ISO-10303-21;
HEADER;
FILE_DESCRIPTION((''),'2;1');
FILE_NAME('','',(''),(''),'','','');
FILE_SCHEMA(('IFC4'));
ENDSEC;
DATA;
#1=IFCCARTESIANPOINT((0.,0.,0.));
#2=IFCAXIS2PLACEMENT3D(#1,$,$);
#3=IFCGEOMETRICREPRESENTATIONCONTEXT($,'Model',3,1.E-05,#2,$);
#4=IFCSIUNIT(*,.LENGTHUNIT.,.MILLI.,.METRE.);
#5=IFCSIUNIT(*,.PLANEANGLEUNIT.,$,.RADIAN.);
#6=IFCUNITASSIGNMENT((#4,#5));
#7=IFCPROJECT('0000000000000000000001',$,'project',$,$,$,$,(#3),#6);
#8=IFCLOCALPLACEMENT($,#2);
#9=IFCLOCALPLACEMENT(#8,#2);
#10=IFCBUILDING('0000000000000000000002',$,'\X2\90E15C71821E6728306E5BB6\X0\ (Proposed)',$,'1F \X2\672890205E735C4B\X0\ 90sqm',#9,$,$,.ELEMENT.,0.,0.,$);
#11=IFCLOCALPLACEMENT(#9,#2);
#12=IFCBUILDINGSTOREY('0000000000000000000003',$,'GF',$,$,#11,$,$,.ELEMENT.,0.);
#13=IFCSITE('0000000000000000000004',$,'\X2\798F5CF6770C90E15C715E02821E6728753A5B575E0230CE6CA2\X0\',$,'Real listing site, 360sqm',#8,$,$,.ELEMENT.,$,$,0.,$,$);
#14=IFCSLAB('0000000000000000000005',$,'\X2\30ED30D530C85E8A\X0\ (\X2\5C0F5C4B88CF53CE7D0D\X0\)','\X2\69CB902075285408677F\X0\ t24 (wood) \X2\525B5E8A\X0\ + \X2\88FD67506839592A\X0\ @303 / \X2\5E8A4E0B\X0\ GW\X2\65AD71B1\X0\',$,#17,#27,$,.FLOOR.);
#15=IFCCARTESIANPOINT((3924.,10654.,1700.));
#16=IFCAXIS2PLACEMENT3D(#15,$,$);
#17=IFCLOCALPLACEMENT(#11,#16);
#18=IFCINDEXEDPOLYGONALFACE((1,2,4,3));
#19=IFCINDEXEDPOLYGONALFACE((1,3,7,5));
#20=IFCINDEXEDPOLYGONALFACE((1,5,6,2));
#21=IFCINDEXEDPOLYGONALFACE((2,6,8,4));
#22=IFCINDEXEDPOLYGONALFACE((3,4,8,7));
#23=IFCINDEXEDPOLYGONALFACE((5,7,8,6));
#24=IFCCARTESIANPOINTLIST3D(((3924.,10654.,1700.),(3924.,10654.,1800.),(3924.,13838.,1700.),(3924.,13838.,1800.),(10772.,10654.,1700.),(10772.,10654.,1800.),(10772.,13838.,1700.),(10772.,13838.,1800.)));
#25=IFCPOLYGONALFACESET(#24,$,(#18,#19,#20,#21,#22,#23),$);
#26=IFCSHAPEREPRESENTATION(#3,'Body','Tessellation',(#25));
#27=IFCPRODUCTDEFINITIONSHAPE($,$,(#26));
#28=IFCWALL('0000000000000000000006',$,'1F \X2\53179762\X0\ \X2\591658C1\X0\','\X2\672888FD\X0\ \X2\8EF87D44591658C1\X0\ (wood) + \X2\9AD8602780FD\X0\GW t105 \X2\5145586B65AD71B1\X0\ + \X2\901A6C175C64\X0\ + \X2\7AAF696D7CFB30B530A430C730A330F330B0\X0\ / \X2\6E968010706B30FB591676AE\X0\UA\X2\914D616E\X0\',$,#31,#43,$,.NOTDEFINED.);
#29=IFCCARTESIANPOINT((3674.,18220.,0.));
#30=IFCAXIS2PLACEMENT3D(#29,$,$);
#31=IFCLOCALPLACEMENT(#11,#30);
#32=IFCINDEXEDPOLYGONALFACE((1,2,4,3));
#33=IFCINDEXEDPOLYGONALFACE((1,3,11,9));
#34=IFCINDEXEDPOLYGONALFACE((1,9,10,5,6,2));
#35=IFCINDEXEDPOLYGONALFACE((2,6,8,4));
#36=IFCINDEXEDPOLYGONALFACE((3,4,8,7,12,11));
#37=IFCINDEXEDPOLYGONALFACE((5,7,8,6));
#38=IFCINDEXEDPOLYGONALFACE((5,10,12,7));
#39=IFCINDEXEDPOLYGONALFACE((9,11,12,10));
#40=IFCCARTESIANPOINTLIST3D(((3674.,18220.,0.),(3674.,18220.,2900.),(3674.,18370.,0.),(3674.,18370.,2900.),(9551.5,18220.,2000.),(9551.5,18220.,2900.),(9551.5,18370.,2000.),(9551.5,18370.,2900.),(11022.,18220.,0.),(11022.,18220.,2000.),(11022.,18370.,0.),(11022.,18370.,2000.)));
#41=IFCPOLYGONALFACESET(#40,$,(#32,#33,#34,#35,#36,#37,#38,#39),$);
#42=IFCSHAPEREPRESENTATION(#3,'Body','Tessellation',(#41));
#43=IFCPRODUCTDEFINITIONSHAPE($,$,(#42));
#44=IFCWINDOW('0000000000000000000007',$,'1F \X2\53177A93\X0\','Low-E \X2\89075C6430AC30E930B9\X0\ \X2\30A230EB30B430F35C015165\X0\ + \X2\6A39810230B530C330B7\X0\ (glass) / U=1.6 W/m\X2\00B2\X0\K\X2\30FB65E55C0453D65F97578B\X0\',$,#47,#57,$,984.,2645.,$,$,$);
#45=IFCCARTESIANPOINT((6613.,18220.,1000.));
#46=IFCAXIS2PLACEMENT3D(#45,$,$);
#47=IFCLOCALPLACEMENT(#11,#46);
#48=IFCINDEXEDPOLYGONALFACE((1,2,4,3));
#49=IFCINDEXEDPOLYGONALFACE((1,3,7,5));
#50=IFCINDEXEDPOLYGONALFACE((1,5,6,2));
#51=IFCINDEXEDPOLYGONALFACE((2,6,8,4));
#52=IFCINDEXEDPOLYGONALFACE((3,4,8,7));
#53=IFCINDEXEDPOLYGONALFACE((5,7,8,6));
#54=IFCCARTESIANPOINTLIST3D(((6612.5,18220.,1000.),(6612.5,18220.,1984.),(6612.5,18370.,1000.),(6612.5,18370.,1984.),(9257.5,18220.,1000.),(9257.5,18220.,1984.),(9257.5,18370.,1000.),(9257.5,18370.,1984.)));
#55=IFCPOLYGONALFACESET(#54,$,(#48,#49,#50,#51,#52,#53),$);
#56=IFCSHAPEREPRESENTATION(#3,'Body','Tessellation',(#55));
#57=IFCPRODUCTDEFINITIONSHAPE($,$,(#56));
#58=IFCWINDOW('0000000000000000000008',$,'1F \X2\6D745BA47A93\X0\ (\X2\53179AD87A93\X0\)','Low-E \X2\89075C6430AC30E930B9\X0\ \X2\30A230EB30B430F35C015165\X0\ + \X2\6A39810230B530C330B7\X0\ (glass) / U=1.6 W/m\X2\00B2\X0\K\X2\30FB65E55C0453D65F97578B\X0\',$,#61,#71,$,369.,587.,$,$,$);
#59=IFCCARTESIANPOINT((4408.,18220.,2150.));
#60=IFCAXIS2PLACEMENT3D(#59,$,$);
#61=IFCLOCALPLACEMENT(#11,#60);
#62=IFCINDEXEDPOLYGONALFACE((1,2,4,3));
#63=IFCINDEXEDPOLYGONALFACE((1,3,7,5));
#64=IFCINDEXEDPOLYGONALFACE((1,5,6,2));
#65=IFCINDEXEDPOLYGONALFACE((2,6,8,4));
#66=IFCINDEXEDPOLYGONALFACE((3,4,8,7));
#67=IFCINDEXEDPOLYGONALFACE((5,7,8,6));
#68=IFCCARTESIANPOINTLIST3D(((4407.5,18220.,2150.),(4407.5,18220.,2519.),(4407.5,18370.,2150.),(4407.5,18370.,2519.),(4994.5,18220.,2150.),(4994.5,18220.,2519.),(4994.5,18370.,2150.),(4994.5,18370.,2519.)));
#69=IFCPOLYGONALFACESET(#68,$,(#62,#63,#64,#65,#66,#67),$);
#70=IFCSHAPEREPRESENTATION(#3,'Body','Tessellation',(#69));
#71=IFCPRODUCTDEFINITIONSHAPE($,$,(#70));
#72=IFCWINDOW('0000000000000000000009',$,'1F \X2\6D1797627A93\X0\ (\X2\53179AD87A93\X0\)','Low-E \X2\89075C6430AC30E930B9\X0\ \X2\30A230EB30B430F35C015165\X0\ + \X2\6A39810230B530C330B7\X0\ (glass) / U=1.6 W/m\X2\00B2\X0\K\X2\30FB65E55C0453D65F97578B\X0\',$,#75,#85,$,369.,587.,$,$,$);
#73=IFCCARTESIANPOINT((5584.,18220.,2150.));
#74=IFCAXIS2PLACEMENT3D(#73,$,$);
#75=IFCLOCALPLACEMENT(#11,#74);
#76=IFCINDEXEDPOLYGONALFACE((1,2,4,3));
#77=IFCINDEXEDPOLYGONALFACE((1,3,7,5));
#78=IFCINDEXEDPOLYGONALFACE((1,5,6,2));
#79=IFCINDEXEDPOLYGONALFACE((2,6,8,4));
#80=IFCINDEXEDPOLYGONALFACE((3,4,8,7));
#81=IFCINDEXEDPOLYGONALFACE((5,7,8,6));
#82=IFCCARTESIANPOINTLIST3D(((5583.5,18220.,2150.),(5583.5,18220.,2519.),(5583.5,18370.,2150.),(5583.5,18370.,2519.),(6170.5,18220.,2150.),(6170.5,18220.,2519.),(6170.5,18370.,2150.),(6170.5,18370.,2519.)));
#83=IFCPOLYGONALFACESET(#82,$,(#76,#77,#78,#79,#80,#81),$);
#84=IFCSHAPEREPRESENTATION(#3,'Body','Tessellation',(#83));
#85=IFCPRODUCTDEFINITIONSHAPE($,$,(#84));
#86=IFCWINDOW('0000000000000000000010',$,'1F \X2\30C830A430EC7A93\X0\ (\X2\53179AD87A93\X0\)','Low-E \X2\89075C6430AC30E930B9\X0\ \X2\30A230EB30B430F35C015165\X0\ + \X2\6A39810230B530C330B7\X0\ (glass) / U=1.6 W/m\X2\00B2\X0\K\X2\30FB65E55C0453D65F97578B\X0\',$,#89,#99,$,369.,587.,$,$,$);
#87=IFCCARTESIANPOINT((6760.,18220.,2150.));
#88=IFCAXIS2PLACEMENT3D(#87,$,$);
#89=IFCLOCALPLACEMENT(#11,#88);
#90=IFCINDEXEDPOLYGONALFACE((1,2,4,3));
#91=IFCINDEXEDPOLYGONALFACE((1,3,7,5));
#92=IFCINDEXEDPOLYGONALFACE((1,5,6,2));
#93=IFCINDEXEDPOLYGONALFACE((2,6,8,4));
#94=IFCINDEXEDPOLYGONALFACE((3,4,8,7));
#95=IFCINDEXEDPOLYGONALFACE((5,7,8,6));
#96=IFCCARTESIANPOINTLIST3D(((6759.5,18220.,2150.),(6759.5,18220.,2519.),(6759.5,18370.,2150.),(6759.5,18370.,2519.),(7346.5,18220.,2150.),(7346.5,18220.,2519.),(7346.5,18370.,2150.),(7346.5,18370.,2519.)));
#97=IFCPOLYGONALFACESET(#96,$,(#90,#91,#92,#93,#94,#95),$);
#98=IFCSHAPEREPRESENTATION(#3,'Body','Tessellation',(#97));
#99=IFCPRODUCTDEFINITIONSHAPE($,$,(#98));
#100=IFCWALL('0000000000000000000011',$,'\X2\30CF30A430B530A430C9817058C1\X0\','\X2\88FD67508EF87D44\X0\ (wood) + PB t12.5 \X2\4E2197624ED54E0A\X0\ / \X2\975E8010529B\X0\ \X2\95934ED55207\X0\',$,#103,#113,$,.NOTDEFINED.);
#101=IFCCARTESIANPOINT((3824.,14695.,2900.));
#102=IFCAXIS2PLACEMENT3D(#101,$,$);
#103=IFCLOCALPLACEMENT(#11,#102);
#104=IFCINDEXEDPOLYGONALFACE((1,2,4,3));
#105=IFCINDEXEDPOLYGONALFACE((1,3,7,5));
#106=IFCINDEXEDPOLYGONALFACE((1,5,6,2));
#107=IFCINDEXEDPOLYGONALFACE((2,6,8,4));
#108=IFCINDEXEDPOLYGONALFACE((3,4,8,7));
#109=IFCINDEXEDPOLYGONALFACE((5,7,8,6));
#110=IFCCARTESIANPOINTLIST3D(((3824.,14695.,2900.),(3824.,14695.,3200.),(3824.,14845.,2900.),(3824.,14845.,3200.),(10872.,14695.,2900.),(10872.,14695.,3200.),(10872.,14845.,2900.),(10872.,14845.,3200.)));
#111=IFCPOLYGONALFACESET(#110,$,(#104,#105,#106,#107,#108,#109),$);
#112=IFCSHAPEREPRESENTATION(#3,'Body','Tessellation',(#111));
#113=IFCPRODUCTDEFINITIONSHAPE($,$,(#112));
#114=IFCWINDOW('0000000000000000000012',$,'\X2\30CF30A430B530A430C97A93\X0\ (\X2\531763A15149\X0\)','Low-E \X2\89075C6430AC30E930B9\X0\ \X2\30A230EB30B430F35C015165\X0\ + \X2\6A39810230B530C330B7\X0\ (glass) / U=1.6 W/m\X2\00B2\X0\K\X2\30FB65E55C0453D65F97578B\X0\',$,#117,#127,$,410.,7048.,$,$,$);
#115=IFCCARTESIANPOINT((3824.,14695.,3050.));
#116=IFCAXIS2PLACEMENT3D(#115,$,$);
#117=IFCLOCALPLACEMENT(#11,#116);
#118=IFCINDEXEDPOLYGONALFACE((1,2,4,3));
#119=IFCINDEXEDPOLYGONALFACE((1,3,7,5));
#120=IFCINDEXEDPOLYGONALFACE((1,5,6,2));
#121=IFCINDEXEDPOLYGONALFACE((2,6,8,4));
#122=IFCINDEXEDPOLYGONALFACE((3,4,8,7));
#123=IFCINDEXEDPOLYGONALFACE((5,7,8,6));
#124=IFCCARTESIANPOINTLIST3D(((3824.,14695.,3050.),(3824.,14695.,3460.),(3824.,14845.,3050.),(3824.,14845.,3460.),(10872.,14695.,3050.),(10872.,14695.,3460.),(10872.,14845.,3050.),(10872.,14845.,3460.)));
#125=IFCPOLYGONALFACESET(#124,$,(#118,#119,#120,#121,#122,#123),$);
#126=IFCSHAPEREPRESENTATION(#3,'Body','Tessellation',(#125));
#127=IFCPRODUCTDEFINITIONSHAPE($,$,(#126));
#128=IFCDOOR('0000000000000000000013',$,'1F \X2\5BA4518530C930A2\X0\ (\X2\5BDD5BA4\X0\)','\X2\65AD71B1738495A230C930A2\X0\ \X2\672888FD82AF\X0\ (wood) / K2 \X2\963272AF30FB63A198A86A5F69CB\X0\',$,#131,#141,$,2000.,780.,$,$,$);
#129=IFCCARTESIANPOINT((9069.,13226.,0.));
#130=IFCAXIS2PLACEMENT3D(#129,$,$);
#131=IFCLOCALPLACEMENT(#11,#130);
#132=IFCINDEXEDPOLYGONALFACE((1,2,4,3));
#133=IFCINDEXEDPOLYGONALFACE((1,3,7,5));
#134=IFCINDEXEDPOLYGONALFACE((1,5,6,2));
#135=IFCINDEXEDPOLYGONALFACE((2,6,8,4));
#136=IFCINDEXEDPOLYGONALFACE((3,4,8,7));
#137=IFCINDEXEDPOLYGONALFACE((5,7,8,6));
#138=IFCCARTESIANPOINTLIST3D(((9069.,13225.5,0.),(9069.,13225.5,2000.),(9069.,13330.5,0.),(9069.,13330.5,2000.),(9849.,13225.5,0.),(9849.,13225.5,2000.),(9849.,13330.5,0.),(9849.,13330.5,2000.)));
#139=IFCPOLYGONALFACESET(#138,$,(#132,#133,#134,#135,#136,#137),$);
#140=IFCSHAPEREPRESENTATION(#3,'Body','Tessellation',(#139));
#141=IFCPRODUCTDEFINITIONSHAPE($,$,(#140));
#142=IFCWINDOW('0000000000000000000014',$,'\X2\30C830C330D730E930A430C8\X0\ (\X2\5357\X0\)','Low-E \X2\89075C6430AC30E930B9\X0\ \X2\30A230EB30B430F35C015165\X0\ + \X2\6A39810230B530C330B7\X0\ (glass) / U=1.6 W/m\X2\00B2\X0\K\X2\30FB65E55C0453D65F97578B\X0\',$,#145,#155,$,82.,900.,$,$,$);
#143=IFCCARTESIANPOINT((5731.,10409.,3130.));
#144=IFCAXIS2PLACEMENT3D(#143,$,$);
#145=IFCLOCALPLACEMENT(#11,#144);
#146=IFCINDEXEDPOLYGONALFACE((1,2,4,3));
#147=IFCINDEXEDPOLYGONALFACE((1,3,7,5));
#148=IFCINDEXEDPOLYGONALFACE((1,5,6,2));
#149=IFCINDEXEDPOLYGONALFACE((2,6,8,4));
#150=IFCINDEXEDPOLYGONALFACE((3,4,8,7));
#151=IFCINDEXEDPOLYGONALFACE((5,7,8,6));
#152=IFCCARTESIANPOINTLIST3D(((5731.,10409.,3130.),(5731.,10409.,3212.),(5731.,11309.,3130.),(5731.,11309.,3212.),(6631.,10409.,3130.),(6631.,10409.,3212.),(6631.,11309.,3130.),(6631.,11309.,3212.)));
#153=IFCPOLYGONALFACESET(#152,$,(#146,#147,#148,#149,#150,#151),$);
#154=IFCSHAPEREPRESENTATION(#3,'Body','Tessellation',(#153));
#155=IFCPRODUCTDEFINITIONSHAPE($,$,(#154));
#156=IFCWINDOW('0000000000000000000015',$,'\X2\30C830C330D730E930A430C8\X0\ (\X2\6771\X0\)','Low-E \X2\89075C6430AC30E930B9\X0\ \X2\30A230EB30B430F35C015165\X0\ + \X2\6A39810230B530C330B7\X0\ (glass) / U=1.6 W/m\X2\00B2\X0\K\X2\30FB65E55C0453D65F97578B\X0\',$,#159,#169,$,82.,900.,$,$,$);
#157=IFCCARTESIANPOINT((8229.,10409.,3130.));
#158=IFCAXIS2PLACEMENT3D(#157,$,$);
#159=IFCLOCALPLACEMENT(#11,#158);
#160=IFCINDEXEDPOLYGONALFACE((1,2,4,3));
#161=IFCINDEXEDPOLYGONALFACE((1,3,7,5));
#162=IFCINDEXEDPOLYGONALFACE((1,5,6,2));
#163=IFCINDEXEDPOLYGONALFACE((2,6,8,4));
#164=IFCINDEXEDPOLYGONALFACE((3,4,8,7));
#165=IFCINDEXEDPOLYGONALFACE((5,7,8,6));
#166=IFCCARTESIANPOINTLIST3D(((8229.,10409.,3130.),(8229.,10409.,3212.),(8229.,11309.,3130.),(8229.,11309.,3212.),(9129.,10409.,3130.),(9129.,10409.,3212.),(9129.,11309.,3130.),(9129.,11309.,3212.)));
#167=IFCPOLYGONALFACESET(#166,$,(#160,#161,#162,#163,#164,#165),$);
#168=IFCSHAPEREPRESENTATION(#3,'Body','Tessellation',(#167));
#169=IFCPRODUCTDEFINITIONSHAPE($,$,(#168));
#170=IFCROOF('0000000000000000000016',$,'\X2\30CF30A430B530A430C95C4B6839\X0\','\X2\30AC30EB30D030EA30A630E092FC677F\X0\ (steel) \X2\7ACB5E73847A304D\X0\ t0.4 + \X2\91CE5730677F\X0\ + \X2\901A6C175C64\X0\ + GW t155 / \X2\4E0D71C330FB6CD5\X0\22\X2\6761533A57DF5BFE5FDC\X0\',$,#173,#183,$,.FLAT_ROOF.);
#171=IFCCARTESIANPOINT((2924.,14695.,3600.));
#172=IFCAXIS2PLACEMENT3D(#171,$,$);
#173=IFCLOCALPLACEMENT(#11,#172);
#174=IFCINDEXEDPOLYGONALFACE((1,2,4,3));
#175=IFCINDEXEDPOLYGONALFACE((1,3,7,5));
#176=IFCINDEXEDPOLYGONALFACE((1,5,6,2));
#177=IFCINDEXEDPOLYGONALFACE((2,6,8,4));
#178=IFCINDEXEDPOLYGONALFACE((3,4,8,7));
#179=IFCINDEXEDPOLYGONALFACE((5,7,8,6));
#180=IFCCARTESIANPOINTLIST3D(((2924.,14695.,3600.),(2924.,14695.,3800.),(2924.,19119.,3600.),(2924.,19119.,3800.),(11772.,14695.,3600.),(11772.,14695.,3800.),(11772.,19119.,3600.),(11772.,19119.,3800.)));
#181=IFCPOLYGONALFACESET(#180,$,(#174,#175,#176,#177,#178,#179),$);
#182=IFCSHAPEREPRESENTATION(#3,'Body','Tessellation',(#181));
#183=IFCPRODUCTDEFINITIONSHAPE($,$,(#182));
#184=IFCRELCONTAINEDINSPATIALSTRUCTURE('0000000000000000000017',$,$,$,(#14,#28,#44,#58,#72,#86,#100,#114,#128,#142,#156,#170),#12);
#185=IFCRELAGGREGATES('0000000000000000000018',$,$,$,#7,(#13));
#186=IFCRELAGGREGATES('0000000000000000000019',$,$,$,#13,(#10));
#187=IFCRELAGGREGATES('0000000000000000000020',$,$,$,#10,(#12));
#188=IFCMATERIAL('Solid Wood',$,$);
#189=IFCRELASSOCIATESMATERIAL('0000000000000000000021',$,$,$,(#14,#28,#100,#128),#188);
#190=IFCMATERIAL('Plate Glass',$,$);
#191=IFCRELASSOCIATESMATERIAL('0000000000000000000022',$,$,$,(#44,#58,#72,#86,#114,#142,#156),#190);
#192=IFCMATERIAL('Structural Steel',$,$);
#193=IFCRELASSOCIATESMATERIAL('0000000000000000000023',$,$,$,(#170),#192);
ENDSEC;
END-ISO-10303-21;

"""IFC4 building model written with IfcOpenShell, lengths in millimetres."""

from ifc_helpers import new_model, si_unit, frame, frame_2d, origin, place, context, project, spatial, rectangle, extrude, material, element, fill, save


model = new_model("IFC4")

# Units and contexts
model_context = context("Model", 3, precision=1e-05, world=origin())
ifc_project = project(units=[si_unit("LENGTHUNIT", "METRE", prefix="MILLI"), si_unit("PLANEANGLEUNIT", "RADIAN")], contexts=[model_context])

# Site, building, storey
site_placement = place(None, origin())
site = spatial("IfcSite", under=ifc_project, at=site_placement, Name="福島県郡山市舞木町字市ノ沢", ObjectType="Real listing site, 360sqm", CompositionType="ELEMENT", RefElevation=0.0)
building_placement = place(site_placement, origin())
building = spatial("IfcBuilding", under=site, at=building_placement, Name="郡山舞木の家 (Proposed)", ObjectType="1F 木造平屋 90sqm", CompositionType="ELEMENT", ElevationOfRefHeight=0.0, ElevationOfTerrain=0.0)
storey_placement = place(building_placement, origin())
storey = spatial("IfcBuildingStorey", under=building, at=storey_placement, Name="GF", CompositionType="ELEMENT", Elevation=0.0)

# Slab
ifc_material_1 = material(Name="Solid Wood")
slab_placement = place(storey_placement, frame((3924.0, 10654.0, 1700.0)))
element("IfcSlab", 1, at=slab_placement, inside=storey, material=ifc_material_1, Name="ロフト床 (小屋裏収納)", Description="構造用合板 t24 (wood) 剛床 + 製材根太 @303 / 床下 GW断熱", PredefinedType="FLOOR", context=model_context, shape_type="SweptSolid", body=[
    extrude(rectangle(XDim=6848.0, YDim=3184.0, at=frame_2d((3424.0, 1592.0))), frame((3924.0, 10654.0, 1700.0)), (0.0, 0.0, 1.0), 100.0),
])

# Wall, openings, windows
wall_1_placement = place(storey_placement, frame((3674.0, 18220.0, 0.0)))
wall_1 = element("IfcWall", 2, at=wall_1_placement, inside=storey, material=ifc_material_1, Name="1F 北面 外壁", Description="木製 軸組外壁 (wood) + 高性能GW t105 充填断熱 + 通気層 + 窯業系サイディング / 準耐火・外皮UA配慮", PredefinedType="NOTDEFINED", context=model_context, shape_type="SweptSolid", body=[
    extrude(rectangle(XDim=7348.0, YDim=150.0, at=frame_2d((3674.0, 75.0))), frame((3674.0, 18220.0, 0.0)), (0.0, 0.0, 1.0), 2900.0),
])
opening_1_placement = place(storey_placement, frame((6613.0, 18220.0, 1000.0)))
opening_1 = element("IfcOpeningElement", 3, at=opening_1_placement, cuts=wall_1, PredefinedType="NOTDEFINED", context=model_context, shape_type="SweptSolid", body=[
    extrude(rectangle(XDim=2645.0, YDim=150.0, at=frame_2d((1322.0, 75.0))), frame((6613.0, 18220.0, 1000.0)), (0.0, 0.0, 1.0), 984.0),
])
opening_2_placement = place(storey_placement, frame((4408.0, 18220.0, 2150.0)))
opening_2 = element("IfcOpeningElement", 4, at=opening_2_placement, cuts=wall_1, PredefinedType="NOTDEFINED", context=model_context, shape_type="SweptSolid", body=[
    extrude(rectangle(XDim=587.0, YDim=150.0, at=frame_2d((293.0, 75.0))), frame((4408.0, 18220.0, 2150.0)), (0.0, 0.0, 1.0), 369.0),
])
opening_3_placement = place(storey_placement, frame((5584.0, 18220.0, 2150.0)))
opening_3 = element("IfcOpeningElement", 5, at=opening_3_placement, cuts=wall_1, PredefinedType="NOTDEFINED", context=model_context, shape_type="SweptSolid", body=[
    extrude(rectangle(XDim=587.0, YDim=150.0, at=frame_2d((293.0, 75.0))), frame((5584.0, 18220.0, 2150.0)), (0.0, 0.0, 1.0), 369.0),
])
opening_4_placement = place(storey_placement, frame((6760.0, 18220.0, 2150.0)))
opening_4 = element("IfcOpeningElement", 6, at=opening_4_placement, cuts=wall_1, PredefinedType="NOTDEFINED", context=model_context, shape_type="SweptSolid", body=[
    extrude(rectangle(XDim=587.0, YDim=150.0, at=frame_2d((293.0, 75.0))), frame((6760.0, 18220.0, 2150.0)), (0.0, 0.0, 1.0), 369.0),
])
ifc_material_2 = material(Name="Plate Glass")
window_1_placement = place(storey_placement, frame((6613.0, 18220.0, 1000.0)))
window_1 = element("IfcWindow", 7, at=window_1_placement, inside=storey, material=ifc_material_2, Name="1F 北窓", Description="Low-E 複層ガラス アルゴン封入 + 樹脂サッシ (glass) / U=1.6 W/m²K・日射取得型", OverallHeight=984.0, OverallWidth=2645.0, context=model_context, shape_type="SweptSolid", body=[
    extrude(rectangle(XDim=2645.0, YDim=150.0, at=frame_2d((1322.0, 75.0))), frame((6613.0, 18220.0, 1000.0)), (0.0, 0.0, 1.0), 984.0),
])
fill(opening_1, window_1)
window_2_placement = place(storey_placement, frame((4408.0, 18220.0, 2150.0)))
window_2 = element("IfcWindow", 8, at=window_2_placement, inside=storey, material=ifc_material_2, Name="1F 浴室窓 (北高窓)", Description="Low-E 複層ガラス アルゴン封入 + 樹脂サッシ (glass) / U=1.6 W/m²K・日射取得型", OverallHeight=369.0, OverallWidth=587.0, context=model_context, shape_type="SweptSolid", body=[
    extrude(rectangle(XDim=587.0, YDim=150.0, at=frame_2d((293.0, 75.0))), frame((4408.0, 18220.0, 2150.0)), (0.0, 0.0, 1.0), 369.0),
])
fill(opening_2, window_2)
window_3_placement = place(storey_placement, frame((5584.0, 18220.0, 2150.0)))
window_3 = element("IfcWindow", 9, at=window_3_placement, inside=storey, material=ifc_material_2, Name="1F 洗面窓 (北高窓)", Description="Low-E 複層ガラス アルゴン封入 + 樹脂サッシ (glass) / U=1.6 W/m²K・日射取得型", OverallHeight=369.0, OverallWidth=587.0, context=model_context, shape_type="SweptSolid", body=[
    extrude(rectangle(XDim=587.0, YDim=150.0, at=frame_2d((293.0, 75.0))), frame((5584.0, 18220.0, 2150.0)), (0.0, 0.0, 1.0), 369.0),
])
fill(opening_3, window_3)
window_4_placement = place(storey_placement, frame((6760.0, 18220.0, 2150.0)))
window_4 = element("IfcWindow", 10, at=window_4_placement, inside=storey, material=ifc_material_2, Name="1F トイレ窓 (北高窓)", Description="Low-E 複層ガラス アルゴン封入 + 樹脂サッシ (glass) / U=1.6 W/m²K・日射取得型", OverallHeight=369.0, OverallWidth=587.0, context=model_context, shape_type="SweptSolid", body=[
    extrude(rectangle(XDim=587.0, YDim=150.0, at=frame_2d((293.0, 75.0))), frame((6760.0, 18220.0, 2150.0)), (0.0, 0.0, 1.0), 369.0),
])
fill(opening_4, window_4)

# Wall, opening, window
wall_2_placement = place(storey_placement, frame((3824.0, 14695.0, 2900.0)))
wall_2 = element("IfcWall", 11, at=wall_2_placement, inside=storey, material=ifc_material_1, Name="ハイサイド腰壁", Description="製材軸組 (wood) + PB t12.5 両面仕上 / 非耐力 間仕切", PredefinedType="NOTDEFINED", context=model_context, shape_type="SweptSolid", body=[
    extrude(rectangle(XDim=7048.0, YDim=150.0, at=frame_2d((3524.0, 75.0))), frame((3824.0, 14695.0, 2900.0)), (0.0, 0.0, 1.0), 700.0),
])
opening_5_placement = place(storey_placement, frame((3824.0, 14695.0, 3050.0)))
opening_5 = element("IfcOpeningElement", 12, at=opening_5_placement, cuts=wall_2, PredefinedType="NOTDEFINED", context=model_context, shape_type="SweptSolid", body=[
    extrude(rectangle(XDim=7048.0, YDim=150.0, at=frame_2d((3524.0, 75.0))), frame((3824.0, 14695.0, 3050.0)), (0.0, 0.0, 1.0), 410.0),
])
window_5_placement = place(storey_placement, frame((3824.0, 14695.0, 3050.0)))
window_5 = element("IfcWindow", 13, at=window_5_placement, inside=storey, material=ifc_material_2, Name="ハイサイド窓 (北採光)", Description="Low-E 複層ガラス アルゴン封入 + 樹脂サッシ (glass) / U=1.6 W/m²K・日射取得型", OverallHeight=410.0, OverallWidth=7048.0, context=model_context, shape_type="SweptSolid", body=[
    extrude(rectangle(XDim=7048.0, YDim=150.0, at=frame_2d((3524.0, 75.0))), frame((3824.0, 14695.0, 3050.0)), (0.0, 0.0, 1.0), 410.0),
])
fill(opening_5, window_5)

# Door
door_1_placement = place(storey_placement, frame((9069.0, 13226.0, 0.0)))
element("IfcDoor", 14, at=door_1_placement, inside=storey, material=ifc_material_1, Name="1F 室内ドア (寝室)", Description="断熱玄関ドア 木製芯 (wood) / K2 防犯・採風機構", OverallHeight=2000.0, OverallWidth=780.0, context=model_context, shape_type="SweptSolid", body=[
    extrude(rectangle(XDim=780.0, YDim=105.0, at=frame_2d((390.0, 52.0))), frame((9069.0, 13226.0, 0.0)), (0.0, 0.0, 1.0), 2000.0),
])

# Windows
window_6_placement = place(storey_placement, frame((5731.0, 10409.0, 3130.0)))
element("IfcWindow", 15, at=window_6_placement, inside=storey, material=ifc_material_2, Name="トップライト (南)", Description="Low-E 複層ガラス アルゴン封入 + 樹脂サッシ (glass) / U=1.6 W/m²K・日射取得型", OverallHeight=82.0, OverallWidth=900.0, context=model_context, shape_type="SweptSolid", body=[
    extrude(rectangle(XDim=900.0, YDim=900.0, at=frame_2d((450.0, 450.0))), frame((5731.0, 10409.0, 3130.0)), (0.0, 0.0, 1.0), 82.0),
])
window_7_placement = place(storey_placement, frame((8229.0, 10409.0, 3130.0)))
element("IfcWindow", 16, at=window_7_placement, inside=storey, material=ifc_material_2, Name="トップライト (東)", Description="Low-E 複層ガラス アルゴン封入 + 樹脂サッシ (glass) / U=1.6 W/m²K・日射取得型", OverallHeight=82.0, OverallWidth=900.0, context=model_context, shape_type="SweptSolid", body=[
    extrude(rectangle(XDim=900.0, YDim=900.0, at=frame_2d((450.0, 450.0))), frame((8229.0, 10409.0, 3130.0)), (0.0, 0.0, 1.0), 82.0),
])

# Roof
ifc_material_3 = material(Name="Structural Steel")
roof_placement = place(storey_placement, frame((2924.0, 14695.0, 3600.0)))
element("IfcRoof", 17, at=roof_placement, inside=storey, material=ifc_material_3, Name="ハイサイド屋根", Description="ガルバリウム鋼板 (steel) 立平葺き t0.4 + 野地板 + 通気層 + GW t155 / 不燃・法22条区域対応", PredefinedType="FLAT_ROOF", context=model_context, shape_type="SweptSolid", body=[
    extrude(rectangle(XDim=8848.0, YDim=4424.0, at=frame_2d((4424.0, 2212.0))), frame((2924.0, 14695.0, 3600.0)), (0.0, 0.0, 1.0), 200.0),
])

save(model, "model.ifc")
